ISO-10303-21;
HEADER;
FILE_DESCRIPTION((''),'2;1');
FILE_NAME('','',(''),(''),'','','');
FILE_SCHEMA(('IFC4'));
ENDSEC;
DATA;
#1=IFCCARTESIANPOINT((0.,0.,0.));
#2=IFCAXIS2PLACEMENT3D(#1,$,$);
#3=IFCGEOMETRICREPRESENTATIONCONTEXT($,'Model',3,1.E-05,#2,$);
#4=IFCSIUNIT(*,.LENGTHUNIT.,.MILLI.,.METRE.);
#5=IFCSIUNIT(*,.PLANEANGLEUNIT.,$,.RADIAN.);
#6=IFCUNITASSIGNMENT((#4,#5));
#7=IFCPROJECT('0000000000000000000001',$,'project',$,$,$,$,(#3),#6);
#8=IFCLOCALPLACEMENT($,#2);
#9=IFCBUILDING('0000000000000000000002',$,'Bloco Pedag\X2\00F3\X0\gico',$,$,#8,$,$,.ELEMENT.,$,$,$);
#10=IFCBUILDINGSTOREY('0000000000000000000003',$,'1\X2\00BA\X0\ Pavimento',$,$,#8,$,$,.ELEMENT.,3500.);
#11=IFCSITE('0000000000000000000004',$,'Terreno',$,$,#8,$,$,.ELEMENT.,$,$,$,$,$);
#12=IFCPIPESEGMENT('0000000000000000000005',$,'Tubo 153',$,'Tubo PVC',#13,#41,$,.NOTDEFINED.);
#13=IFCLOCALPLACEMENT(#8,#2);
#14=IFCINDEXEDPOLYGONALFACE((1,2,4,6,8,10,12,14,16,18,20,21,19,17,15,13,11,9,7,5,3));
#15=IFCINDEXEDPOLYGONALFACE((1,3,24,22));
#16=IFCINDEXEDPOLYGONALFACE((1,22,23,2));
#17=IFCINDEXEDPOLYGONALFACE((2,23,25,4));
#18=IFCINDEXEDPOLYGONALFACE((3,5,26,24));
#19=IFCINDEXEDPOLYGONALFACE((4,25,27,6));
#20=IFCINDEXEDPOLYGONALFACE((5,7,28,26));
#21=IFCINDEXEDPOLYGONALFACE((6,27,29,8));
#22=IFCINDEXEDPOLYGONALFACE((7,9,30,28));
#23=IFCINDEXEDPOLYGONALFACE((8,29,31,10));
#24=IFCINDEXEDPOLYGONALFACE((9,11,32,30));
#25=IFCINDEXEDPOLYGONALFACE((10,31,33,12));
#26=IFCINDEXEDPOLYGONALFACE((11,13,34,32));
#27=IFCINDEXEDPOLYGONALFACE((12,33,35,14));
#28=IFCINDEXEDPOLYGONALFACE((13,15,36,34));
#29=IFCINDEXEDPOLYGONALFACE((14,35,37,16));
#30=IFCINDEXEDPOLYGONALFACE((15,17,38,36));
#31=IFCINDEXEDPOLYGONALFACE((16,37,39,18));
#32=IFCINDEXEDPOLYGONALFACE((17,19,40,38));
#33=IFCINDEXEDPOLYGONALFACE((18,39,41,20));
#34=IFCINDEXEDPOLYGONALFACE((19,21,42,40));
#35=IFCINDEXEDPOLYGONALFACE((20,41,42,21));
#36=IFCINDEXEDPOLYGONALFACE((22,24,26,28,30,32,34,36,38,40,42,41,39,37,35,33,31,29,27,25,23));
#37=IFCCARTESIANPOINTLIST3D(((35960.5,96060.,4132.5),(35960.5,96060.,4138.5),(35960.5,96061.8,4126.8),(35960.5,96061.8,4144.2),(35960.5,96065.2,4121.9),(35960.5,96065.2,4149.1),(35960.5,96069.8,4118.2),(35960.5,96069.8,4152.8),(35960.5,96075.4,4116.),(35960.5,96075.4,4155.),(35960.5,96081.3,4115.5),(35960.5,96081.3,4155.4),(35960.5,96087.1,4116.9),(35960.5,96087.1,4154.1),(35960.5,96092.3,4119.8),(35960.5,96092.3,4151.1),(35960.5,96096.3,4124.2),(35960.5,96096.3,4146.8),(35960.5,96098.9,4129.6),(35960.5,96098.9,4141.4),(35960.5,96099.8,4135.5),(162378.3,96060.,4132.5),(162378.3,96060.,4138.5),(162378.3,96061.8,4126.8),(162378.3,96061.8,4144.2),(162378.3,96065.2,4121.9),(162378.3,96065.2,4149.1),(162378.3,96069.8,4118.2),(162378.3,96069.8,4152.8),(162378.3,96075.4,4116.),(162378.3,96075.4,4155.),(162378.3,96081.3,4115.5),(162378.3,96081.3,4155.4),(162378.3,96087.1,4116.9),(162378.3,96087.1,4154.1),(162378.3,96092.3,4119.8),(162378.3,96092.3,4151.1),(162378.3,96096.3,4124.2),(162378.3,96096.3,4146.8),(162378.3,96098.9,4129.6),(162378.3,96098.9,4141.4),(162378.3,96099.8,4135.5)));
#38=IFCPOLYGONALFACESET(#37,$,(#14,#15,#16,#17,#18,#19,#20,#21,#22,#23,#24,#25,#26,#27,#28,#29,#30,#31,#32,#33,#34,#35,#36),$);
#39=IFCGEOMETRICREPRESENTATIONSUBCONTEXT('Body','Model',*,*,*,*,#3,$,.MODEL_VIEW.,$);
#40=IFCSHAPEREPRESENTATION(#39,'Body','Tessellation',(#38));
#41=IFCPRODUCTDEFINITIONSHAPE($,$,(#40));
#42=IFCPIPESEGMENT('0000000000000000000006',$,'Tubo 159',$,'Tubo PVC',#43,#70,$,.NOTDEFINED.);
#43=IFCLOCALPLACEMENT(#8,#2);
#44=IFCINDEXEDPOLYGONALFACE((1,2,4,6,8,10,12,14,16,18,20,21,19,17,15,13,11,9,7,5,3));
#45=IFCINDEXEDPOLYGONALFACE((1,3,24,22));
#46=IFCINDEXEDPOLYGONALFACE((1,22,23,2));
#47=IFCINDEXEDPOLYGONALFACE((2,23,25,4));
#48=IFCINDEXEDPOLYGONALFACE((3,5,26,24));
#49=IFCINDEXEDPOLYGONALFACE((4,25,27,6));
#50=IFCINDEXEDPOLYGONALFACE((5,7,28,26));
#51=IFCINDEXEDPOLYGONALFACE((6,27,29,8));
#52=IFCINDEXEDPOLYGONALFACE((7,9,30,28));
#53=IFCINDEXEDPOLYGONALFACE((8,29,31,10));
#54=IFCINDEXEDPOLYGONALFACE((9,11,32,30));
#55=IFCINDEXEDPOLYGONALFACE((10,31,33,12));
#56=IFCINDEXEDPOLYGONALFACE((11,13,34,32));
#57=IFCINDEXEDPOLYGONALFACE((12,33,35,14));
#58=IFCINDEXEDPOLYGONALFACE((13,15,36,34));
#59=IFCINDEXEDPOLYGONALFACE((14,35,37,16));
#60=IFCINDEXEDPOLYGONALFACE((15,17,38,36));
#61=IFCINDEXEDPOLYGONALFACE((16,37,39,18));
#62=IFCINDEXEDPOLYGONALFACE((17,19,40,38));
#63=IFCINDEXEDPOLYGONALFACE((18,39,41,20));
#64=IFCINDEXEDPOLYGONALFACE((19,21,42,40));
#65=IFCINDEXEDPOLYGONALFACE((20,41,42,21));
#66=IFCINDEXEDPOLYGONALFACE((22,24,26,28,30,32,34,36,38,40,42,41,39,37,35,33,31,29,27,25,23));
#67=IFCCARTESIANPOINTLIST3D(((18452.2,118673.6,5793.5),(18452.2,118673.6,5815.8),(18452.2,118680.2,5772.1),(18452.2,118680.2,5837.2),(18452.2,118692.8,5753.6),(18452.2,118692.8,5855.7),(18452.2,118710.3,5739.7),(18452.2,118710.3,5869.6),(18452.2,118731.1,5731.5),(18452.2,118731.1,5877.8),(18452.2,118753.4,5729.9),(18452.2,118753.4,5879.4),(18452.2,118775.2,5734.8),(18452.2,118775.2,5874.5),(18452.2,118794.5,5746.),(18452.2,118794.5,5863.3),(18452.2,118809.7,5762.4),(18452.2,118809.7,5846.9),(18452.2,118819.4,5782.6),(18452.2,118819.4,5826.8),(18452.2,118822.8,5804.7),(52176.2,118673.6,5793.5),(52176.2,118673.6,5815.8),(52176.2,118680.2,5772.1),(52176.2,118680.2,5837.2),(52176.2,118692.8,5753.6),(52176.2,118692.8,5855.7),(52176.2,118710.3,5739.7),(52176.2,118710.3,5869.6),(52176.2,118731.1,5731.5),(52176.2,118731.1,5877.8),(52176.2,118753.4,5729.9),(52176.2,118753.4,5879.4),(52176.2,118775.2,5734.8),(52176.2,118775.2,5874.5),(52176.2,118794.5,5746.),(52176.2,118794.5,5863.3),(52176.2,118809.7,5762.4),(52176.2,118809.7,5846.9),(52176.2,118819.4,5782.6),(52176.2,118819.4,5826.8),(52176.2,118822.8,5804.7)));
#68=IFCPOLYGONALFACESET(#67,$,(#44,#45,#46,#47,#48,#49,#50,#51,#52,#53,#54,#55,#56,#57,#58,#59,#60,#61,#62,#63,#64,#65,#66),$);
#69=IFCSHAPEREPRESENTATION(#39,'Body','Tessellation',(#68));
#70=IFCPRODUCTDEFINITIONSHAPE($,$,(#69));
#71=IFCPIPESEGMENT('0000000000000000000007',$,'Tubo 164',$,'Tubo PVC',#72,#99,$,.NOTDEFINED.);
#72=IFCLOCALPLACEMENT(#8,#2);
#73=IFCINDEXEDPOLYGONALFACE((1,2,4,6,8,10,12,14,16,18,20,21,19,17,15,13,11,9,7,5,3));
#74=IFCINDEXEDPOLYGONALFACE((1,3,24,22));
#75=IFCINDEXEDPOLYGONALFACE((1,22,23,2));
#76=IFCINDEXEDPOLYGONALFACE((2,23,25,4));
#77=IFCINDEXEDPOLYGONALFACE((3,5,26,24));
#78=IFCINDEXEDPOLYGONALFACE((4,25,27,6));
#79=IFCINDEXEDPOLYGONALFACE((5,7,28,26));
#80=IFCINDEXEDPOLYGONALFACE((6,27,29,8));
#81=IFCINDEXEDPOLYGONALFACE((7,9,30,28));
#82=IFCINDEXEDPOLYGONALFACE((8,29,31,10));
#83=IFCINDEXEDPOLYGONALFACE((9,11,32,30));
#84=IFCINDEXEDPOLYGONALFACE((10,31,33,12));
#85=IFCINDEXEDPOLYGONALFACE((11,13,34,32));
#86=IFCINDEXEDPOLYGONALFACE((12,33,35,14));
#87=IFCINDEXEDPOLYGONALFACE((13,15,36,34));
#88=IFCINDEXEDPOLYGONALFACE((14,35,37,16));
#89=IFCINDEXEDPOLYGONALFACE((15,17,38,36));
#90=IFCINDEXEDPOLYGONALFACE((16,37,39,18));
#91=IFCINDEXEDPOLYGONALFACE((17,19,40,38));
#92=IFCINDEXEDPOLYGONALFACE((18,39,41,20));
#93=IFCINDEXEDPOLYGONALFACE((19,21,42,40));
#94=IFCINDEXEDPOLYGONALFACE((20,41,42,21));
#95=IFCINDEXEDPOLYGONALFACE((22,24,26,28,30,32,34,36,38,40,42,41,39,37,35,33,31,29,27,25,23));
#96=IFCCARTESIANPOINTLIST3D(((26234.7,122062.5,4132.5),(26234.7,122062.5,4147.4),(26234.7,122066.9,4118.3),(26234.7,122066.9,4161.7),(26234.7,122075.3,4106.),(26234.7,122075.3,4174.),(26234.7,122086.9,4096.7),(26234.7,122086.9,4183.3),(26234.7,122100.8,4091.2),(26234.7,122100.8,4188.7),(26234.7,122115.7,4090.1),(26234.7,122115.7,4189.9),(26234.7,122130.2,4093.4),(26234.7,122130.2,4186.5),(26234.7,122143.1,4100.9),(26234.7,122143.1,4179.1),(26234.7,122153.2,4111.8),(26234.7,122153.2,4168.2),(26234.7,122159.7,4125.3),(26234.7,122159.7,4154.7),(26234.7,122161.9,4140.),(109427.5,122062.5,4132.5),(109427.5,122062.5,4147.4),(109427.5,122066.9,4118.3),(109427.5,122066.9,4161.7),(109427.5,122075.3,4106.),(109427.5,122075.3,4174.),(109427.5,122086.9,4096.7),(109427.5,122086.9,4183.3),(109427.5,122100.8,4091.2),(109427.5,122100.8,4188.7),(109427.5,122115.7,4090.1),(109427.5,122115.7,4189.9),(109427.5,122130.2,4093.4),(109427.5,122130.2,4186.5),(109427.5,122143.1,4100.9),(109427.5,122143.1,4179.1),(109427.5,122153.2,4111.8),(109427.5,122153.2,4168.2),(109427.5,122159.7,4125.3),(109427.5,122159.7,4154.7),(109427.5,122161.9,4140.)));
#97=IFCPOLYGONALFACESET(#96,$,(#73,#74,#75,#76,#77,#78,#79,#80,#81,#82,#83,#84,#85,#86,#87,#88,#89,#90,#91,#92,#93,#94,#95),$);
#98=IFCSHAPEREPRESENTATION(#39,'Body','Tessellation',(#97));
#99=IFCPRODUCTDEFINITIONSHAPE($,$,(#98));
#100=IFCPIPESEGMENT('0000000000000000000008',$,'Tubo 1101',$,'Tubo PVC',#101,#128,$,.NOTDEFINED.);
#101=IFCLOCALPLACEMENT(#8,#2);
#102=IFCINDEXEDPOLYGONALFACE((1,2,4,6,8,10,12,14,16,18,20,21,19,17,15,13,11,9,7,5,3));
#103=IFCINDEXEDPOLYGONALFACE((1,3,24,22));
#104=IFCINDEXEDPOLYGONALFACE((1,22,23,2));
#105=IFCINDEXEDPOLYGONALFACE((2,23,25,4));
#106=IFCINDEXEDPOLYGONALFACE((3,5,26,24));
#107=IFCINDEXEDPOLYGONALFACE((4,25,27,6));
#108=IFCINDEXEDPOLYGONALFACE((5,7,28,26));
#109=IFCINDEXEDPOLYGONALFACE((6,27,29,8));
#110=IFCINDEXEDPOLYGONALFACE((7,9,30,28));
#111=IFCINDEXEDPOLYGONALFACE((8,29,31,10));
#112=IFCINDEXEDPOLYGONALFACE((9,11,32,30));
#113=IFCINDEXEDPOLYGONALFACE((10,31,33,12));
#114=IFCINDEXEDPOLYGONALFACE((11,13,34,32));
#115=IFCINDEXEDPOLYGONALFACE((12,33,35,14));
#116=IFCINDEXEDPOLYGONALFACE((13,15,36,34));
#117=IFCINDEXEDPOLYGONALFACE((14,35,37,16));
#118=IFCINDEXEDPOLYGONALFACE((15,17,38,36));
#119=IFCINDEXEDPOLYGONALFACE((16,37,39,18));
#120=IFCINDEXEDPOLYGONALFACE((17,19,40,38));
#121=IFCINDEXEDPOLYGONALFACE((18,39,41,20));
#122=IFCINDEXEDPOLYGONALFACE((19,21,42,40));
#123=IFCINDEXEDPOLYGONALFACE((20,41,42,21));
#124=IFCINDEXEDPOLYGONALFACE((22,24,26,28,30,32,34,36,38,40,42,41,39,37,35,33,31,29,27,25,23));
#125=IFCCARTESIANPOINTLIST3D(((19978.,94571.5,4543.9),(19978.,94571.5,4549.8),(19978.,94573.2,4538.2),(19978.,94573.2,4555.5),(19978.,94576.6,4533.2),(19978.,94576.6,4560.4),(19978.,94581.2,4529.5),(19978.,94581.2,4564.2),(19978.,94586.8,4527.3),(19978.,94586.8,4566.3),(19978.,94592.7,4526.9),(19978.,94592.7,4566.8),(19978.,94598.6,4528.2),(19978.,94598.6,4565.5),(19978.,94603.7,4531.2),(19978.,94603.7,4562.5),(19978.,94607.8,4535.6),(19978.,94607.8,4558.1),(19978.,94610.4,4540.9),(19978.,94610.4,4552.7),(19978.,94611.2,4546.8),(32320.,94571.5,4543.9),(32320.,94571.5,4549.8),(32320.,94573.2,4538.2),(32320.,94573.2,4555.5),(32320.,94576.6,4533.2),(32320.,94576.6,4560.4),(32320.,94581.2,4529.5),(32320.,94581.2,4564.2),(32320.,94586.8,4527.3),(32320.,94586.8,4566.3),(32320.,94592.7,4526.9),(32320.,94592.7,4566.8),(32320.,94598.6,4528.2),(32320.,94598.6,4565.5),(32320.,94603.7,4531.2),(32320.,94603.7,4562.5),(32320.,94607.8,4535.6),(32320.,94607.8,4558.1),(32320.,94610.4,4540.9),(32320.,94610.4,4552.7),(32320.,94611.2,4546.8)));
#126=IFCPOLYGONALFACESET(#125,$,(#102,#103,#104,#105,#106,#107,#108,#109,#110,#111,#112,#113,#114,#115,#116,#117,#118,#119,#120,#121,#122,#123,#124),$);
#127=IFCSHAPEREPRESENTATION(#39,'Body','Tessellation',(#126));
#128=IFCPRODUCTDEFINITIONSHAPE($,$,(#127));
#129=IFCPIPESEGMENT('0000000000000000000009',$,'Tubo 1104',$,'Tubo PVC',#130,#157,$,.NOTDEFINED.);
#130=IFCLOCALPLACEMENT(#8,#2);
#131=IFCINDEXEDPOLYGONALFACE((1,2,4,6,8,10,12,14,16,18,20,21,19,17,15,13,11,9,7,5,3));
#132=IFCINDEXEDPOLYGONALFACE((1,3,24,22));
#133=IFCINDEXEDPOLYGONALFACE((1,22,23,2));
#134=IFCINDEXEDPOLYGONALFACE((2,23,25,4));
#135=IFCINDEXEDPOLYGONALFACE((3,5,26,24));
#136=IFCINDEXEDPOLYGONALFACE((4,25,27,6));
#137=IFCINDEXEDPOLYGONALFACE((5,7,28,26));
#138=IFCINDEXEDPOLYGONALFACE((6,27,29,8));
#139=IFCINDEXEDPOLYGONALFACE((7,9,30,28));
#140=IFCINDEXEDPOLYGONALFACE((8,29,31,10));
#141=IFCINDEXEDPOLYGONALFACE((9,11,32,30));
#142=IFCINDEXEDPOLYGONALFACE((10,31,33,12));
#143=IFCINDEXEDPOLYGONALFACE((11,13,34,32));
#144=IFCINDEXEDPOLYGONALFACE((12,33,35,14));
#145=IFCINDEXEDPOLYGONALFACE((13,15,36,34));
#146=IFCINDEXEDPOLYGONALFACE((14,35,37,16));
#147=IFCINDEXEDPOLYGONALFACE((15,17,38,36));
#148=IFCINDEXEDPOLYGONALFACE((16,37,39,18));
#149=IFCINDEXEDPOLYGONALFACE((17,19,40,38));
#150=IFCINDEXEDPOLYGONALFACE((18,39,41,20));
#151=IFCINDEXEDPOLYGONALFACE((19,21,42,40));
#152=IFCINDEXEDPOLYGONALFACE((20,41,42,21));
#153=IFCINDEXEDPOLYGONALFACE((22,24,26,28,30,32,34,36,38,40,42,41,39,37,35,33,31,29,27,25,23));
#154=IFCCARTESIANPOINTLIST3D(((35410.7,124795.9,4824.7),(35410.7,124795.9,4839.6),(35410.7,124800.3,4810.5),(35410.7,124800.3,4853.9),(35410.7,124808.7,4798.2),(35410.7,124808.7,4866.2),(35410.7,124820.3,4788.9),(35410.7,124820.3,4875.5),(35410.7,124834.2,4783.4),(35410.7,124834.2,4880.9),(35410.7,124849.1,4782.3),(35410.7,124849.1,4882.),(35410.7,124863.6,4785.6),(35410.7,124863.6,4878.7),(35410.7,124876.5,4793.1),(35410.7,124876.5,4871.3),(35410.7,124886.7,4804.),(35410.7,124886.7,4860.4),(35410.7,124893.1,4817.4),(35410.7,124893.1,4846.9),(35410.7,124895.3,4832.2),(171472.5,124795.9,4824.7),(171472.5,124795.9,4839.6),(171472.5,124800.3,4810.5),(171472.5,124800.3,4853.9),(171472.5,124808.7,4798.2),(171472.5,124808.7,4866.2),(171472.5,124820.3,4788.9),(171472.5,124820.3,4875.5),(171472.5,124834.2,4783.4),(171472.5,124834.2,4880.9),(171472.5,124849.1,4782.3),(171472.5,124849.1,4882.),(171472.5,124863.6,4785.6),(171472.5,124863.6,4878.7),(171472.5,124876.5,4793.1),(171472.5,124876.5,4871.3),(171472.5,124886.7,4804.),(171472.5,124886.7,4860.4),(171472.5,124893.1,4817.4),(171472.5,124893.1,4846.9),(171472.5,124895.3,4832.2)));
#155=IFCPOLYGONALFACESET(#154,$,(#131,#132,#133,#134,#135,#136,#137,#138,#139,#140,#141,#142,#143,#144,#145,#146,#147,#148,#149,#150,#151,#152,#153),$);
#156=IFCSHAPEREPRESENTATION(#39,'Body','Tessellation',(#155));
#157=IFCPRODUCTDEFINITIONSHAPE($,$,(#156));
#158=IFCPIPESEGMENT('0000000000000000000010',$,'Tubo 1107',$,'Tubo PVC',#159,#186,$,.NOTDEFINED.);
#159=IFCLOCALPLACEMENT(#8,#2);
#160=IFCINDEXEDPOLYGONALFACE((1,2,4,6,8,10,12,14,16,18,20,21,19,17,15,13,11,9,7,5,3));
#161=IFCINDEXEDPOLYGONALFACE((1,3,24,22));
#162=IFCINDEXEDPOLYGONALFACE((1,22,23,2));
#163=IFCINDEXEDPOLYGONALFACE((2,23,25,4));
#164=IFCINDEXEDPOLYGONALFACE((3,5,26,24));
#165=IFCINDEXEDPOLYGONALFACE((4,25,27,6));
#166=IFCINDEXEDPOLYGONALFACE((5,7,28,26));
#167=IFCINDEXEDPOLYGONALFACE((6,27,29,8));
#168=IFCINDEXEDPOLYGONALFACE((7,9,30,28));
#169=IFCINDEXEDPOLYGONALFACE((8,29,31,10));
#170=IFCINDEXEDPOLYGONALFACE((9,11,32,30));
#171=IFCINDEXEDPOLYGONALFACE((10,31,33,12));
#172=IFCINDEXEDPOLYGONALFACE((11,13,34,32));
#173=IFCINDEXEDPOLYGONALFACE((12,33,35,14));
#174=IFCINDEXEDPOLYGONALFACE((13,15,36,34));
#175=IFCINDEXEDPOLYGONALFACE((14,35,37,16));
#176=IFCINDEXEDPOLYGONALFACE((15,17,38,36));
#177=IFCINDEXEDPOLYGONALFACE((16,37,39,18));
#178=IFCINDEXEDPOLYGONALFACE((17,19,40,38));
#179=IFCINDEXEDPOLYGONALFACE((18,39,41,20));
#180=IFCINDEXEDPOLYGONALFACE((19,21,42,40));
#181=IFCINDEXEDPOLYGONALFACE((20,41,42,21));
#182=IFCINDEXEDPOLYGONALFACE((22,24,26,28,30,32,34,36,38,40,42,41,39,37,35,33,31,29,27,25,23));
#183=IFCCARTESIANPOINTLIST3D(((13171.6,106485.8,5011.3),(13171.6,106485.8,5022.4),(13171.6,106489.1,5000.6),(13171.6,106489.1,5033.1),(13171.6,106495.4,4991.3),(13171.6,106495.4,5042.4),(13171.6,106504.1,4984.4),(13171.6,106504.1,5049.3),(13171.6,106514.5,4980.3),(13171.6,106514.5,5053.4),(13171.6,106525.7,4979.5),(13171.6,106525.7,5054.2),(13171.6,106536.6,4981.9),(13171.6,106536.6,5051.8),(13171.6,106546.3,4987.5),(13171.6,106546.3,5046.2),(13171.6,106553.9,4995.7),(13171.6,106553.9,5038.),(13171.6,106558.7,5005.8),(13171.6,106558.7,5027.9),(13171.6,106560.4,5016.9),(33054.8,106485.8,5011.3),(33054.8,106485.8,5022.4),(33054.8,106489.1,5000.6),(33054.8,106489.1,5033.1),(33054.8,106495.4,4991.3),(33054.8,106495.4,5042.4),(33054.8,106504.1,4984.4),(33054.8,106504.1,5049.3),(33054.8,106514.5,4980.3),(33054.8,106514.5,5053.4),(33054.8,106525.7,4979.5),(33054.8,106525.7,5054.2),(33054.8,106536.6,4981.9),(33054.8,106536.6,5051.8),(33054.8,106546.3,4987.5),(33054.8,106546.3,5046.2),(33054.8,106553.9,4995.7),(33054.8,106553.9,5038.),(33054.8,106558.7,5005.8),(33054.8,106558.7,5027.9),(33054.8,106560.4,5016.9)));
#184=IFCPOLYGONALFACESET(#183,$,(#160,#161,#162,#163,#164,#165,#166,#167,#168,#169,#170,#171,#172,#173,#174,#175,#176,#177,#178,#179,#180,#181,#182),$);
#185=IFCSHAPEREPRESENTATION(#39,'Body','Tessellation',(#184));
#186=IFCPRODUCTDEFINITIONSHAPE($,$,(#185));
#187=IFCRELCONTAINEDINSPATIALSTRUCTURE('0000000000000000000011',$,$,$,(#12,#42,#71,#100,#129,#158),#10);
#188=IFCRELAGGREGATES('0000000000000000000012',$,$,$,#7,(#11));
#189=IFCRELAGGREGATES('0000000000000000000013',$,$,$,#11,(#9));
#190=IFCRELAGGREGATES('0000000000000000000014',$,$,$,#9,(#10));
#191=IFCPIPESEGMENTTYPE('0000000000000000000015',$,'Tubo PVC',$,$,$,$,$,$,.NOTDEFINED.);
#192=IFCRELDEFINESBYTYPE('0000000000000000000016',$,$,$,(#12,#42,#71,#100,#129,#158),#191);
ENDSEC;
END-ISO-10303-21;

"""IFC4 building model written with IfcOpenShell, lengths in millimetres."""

from ifc_helpers import new_model, si_unit, frame, origin, origin_2d, place, context, subcontext, project, spatial, circle, extrude, type_object, element, save


model = new_model("IFC4")

# Units and contexts
model_context = context("Model", 3, precision=1e-05, world=origin())
body_context = subcontext(model_context, "Body", "Model", "MODEL_VIEW")
ifc_project = project(units=[si_unit("LENGTHUNIT", "METRE", prefix="MILLI"), si_unit("PLANEANGLEUNIT", "RADIAN")], contexts=[model_context])

# Site, building, storey
placement = place(None, origin())
site = spatial("IfcSite", under=ifc_project, at=placement, Name="Terreno", CompositionType="ELEMENT")
building = spatial("IfcBuilding", under=site, at=placement, Name="Bloco Pedagógico", CompositionType="ELEMENT")
storey = spatial("IfcBuildingStorey", under=building, at=placement, Name="1º Pavimento", CompositionType="ELEMENT", Elevation=3500.0)

# Pipe segments
pipe_segment_type = type_object("IfcPipeSegmentType", Name="Tubo PVC", PredefinedType="NOTDEFINED")
pipe_segment_1_placement = place(None, frame((35960.5, 96079.8, 4135.5), z_axis=(1.0, 0.0, 0.0), x_axis=(0.0, 1.0, 0.0)))
element("IfcPipeSegment", 1, at=pipe_segment_1_placement, inside=storey, type_object=pipe_segment_type, Name="Tubo 153", ObjectType="Tubo PVC", PredefinedType="NOTDEFINED", context=body_context, shape_type="SweptSolid", body=[
    extrude(circle(Radius=20.0, at=origin_2d()), None, (0.0, 0.0, 1.0), 126417.8),
])
pipe_segment_2_placement = place(None, frame((18452.2, 118747.8, 5804.7), z_axis=(1.0, 0.0, 0.0), x_axis=(0.0, 1.0, 0.0)))
element("IfcPipeSegment", 2, at=pipe_segment_2_placement, inside=storey, type_object=pipe_segment_type, Name="Tubo 159", ObjectType="Tubo PVC", PredefinedType="NOTDEFINED", context=body_context, shape_type="SweptSolid", body=[
    extrude(circle(Radius=75.0, at=origin_2d()), None, (0.0, 0.0, 1.0), 33724.0),
])
pipe_segment_3_placement = place(None, frame((26234.7, 122111.9, 4140.0), z_axis=(1.0, 0.0, 0.0), x_axis=(0.0, 1.0, 0.0)))
element("IfcPipeSegment", 3, at=pipe_segment_3_placement, inside=storey, type_object=pipe_segment_type, Name="Tubo 164", ObjectType="Tubo PVC", PredefinedType="NOTDEFINED", context=body_context, shape_type="SweptSolid", body=[
    extrude(circle(Radius=50.0, at=origin_2d()), None, (0.0, 0.0, 1.0), 83192.8),
])
pipe_segment_4_placement = place(None, frame((19978.0, 94591.2, 4546.8), z_axis=(1.0, 0.0, 0.0), x_axis=(0.0, 1.0, 0.0)))
element("IfcPipeSegment", 4, at=pipe_segment_4_placement, inside=storey, type_object=pipe_segment_type, Name="Tubo 1101", ObjectType="Tubo PVC", PredefinedType="NOTDEFINED", context=body_context, shape_type="SweptSolid", body=[
    extrude(circle(Radius=20.0, at=origin_2d()), None, (0.0, 0.0, 1.0), 12341.9),
])
pipe_segment_5_placement = place(None, frame((35410.7, 124845.3, 4832.2), z_axis=(1.0, 0.0, 0.0), x_axis=(0.0, 1.0, 0.0)))
element("IfcPipeSegment", 5, at=pipe_segment_5_placement, inside=storey, type_object=pipe_segment_type, Name="Tubo 1104", ObjectType="Tubo PVC", PredefinedType="NOTDEFINED", context=body_context, shape_type="SweptSolid", body=[
    extrude(circle(Radius=50.0, at=origin_2d()), None, (0.0, 0.0, 1.0), 136061.8),
])
pipe_segment_6_placement = place(None, frame((13171.6, 106522.9, 5016.9), z_axis=(1.0, 0.0, 0.0), x_axis=(0.0, 1.0, 0.0)))
element("IfcPipeSegment", 6, at=pipe_segment_6_placement, inside=storey, type_object=pipe_segment_type, Name="Tubo 1107", ObjectType="Tubo PVC", PredefinedType="NOTDEFINED", context=body_context, shape_type="SweptSolid", body=[
    extrude(circle(Radius=37.5, at=origin_2d()), None, (0.0, 0.0, 1.0), 19883.2),
])

save(model, "model.ifc")
